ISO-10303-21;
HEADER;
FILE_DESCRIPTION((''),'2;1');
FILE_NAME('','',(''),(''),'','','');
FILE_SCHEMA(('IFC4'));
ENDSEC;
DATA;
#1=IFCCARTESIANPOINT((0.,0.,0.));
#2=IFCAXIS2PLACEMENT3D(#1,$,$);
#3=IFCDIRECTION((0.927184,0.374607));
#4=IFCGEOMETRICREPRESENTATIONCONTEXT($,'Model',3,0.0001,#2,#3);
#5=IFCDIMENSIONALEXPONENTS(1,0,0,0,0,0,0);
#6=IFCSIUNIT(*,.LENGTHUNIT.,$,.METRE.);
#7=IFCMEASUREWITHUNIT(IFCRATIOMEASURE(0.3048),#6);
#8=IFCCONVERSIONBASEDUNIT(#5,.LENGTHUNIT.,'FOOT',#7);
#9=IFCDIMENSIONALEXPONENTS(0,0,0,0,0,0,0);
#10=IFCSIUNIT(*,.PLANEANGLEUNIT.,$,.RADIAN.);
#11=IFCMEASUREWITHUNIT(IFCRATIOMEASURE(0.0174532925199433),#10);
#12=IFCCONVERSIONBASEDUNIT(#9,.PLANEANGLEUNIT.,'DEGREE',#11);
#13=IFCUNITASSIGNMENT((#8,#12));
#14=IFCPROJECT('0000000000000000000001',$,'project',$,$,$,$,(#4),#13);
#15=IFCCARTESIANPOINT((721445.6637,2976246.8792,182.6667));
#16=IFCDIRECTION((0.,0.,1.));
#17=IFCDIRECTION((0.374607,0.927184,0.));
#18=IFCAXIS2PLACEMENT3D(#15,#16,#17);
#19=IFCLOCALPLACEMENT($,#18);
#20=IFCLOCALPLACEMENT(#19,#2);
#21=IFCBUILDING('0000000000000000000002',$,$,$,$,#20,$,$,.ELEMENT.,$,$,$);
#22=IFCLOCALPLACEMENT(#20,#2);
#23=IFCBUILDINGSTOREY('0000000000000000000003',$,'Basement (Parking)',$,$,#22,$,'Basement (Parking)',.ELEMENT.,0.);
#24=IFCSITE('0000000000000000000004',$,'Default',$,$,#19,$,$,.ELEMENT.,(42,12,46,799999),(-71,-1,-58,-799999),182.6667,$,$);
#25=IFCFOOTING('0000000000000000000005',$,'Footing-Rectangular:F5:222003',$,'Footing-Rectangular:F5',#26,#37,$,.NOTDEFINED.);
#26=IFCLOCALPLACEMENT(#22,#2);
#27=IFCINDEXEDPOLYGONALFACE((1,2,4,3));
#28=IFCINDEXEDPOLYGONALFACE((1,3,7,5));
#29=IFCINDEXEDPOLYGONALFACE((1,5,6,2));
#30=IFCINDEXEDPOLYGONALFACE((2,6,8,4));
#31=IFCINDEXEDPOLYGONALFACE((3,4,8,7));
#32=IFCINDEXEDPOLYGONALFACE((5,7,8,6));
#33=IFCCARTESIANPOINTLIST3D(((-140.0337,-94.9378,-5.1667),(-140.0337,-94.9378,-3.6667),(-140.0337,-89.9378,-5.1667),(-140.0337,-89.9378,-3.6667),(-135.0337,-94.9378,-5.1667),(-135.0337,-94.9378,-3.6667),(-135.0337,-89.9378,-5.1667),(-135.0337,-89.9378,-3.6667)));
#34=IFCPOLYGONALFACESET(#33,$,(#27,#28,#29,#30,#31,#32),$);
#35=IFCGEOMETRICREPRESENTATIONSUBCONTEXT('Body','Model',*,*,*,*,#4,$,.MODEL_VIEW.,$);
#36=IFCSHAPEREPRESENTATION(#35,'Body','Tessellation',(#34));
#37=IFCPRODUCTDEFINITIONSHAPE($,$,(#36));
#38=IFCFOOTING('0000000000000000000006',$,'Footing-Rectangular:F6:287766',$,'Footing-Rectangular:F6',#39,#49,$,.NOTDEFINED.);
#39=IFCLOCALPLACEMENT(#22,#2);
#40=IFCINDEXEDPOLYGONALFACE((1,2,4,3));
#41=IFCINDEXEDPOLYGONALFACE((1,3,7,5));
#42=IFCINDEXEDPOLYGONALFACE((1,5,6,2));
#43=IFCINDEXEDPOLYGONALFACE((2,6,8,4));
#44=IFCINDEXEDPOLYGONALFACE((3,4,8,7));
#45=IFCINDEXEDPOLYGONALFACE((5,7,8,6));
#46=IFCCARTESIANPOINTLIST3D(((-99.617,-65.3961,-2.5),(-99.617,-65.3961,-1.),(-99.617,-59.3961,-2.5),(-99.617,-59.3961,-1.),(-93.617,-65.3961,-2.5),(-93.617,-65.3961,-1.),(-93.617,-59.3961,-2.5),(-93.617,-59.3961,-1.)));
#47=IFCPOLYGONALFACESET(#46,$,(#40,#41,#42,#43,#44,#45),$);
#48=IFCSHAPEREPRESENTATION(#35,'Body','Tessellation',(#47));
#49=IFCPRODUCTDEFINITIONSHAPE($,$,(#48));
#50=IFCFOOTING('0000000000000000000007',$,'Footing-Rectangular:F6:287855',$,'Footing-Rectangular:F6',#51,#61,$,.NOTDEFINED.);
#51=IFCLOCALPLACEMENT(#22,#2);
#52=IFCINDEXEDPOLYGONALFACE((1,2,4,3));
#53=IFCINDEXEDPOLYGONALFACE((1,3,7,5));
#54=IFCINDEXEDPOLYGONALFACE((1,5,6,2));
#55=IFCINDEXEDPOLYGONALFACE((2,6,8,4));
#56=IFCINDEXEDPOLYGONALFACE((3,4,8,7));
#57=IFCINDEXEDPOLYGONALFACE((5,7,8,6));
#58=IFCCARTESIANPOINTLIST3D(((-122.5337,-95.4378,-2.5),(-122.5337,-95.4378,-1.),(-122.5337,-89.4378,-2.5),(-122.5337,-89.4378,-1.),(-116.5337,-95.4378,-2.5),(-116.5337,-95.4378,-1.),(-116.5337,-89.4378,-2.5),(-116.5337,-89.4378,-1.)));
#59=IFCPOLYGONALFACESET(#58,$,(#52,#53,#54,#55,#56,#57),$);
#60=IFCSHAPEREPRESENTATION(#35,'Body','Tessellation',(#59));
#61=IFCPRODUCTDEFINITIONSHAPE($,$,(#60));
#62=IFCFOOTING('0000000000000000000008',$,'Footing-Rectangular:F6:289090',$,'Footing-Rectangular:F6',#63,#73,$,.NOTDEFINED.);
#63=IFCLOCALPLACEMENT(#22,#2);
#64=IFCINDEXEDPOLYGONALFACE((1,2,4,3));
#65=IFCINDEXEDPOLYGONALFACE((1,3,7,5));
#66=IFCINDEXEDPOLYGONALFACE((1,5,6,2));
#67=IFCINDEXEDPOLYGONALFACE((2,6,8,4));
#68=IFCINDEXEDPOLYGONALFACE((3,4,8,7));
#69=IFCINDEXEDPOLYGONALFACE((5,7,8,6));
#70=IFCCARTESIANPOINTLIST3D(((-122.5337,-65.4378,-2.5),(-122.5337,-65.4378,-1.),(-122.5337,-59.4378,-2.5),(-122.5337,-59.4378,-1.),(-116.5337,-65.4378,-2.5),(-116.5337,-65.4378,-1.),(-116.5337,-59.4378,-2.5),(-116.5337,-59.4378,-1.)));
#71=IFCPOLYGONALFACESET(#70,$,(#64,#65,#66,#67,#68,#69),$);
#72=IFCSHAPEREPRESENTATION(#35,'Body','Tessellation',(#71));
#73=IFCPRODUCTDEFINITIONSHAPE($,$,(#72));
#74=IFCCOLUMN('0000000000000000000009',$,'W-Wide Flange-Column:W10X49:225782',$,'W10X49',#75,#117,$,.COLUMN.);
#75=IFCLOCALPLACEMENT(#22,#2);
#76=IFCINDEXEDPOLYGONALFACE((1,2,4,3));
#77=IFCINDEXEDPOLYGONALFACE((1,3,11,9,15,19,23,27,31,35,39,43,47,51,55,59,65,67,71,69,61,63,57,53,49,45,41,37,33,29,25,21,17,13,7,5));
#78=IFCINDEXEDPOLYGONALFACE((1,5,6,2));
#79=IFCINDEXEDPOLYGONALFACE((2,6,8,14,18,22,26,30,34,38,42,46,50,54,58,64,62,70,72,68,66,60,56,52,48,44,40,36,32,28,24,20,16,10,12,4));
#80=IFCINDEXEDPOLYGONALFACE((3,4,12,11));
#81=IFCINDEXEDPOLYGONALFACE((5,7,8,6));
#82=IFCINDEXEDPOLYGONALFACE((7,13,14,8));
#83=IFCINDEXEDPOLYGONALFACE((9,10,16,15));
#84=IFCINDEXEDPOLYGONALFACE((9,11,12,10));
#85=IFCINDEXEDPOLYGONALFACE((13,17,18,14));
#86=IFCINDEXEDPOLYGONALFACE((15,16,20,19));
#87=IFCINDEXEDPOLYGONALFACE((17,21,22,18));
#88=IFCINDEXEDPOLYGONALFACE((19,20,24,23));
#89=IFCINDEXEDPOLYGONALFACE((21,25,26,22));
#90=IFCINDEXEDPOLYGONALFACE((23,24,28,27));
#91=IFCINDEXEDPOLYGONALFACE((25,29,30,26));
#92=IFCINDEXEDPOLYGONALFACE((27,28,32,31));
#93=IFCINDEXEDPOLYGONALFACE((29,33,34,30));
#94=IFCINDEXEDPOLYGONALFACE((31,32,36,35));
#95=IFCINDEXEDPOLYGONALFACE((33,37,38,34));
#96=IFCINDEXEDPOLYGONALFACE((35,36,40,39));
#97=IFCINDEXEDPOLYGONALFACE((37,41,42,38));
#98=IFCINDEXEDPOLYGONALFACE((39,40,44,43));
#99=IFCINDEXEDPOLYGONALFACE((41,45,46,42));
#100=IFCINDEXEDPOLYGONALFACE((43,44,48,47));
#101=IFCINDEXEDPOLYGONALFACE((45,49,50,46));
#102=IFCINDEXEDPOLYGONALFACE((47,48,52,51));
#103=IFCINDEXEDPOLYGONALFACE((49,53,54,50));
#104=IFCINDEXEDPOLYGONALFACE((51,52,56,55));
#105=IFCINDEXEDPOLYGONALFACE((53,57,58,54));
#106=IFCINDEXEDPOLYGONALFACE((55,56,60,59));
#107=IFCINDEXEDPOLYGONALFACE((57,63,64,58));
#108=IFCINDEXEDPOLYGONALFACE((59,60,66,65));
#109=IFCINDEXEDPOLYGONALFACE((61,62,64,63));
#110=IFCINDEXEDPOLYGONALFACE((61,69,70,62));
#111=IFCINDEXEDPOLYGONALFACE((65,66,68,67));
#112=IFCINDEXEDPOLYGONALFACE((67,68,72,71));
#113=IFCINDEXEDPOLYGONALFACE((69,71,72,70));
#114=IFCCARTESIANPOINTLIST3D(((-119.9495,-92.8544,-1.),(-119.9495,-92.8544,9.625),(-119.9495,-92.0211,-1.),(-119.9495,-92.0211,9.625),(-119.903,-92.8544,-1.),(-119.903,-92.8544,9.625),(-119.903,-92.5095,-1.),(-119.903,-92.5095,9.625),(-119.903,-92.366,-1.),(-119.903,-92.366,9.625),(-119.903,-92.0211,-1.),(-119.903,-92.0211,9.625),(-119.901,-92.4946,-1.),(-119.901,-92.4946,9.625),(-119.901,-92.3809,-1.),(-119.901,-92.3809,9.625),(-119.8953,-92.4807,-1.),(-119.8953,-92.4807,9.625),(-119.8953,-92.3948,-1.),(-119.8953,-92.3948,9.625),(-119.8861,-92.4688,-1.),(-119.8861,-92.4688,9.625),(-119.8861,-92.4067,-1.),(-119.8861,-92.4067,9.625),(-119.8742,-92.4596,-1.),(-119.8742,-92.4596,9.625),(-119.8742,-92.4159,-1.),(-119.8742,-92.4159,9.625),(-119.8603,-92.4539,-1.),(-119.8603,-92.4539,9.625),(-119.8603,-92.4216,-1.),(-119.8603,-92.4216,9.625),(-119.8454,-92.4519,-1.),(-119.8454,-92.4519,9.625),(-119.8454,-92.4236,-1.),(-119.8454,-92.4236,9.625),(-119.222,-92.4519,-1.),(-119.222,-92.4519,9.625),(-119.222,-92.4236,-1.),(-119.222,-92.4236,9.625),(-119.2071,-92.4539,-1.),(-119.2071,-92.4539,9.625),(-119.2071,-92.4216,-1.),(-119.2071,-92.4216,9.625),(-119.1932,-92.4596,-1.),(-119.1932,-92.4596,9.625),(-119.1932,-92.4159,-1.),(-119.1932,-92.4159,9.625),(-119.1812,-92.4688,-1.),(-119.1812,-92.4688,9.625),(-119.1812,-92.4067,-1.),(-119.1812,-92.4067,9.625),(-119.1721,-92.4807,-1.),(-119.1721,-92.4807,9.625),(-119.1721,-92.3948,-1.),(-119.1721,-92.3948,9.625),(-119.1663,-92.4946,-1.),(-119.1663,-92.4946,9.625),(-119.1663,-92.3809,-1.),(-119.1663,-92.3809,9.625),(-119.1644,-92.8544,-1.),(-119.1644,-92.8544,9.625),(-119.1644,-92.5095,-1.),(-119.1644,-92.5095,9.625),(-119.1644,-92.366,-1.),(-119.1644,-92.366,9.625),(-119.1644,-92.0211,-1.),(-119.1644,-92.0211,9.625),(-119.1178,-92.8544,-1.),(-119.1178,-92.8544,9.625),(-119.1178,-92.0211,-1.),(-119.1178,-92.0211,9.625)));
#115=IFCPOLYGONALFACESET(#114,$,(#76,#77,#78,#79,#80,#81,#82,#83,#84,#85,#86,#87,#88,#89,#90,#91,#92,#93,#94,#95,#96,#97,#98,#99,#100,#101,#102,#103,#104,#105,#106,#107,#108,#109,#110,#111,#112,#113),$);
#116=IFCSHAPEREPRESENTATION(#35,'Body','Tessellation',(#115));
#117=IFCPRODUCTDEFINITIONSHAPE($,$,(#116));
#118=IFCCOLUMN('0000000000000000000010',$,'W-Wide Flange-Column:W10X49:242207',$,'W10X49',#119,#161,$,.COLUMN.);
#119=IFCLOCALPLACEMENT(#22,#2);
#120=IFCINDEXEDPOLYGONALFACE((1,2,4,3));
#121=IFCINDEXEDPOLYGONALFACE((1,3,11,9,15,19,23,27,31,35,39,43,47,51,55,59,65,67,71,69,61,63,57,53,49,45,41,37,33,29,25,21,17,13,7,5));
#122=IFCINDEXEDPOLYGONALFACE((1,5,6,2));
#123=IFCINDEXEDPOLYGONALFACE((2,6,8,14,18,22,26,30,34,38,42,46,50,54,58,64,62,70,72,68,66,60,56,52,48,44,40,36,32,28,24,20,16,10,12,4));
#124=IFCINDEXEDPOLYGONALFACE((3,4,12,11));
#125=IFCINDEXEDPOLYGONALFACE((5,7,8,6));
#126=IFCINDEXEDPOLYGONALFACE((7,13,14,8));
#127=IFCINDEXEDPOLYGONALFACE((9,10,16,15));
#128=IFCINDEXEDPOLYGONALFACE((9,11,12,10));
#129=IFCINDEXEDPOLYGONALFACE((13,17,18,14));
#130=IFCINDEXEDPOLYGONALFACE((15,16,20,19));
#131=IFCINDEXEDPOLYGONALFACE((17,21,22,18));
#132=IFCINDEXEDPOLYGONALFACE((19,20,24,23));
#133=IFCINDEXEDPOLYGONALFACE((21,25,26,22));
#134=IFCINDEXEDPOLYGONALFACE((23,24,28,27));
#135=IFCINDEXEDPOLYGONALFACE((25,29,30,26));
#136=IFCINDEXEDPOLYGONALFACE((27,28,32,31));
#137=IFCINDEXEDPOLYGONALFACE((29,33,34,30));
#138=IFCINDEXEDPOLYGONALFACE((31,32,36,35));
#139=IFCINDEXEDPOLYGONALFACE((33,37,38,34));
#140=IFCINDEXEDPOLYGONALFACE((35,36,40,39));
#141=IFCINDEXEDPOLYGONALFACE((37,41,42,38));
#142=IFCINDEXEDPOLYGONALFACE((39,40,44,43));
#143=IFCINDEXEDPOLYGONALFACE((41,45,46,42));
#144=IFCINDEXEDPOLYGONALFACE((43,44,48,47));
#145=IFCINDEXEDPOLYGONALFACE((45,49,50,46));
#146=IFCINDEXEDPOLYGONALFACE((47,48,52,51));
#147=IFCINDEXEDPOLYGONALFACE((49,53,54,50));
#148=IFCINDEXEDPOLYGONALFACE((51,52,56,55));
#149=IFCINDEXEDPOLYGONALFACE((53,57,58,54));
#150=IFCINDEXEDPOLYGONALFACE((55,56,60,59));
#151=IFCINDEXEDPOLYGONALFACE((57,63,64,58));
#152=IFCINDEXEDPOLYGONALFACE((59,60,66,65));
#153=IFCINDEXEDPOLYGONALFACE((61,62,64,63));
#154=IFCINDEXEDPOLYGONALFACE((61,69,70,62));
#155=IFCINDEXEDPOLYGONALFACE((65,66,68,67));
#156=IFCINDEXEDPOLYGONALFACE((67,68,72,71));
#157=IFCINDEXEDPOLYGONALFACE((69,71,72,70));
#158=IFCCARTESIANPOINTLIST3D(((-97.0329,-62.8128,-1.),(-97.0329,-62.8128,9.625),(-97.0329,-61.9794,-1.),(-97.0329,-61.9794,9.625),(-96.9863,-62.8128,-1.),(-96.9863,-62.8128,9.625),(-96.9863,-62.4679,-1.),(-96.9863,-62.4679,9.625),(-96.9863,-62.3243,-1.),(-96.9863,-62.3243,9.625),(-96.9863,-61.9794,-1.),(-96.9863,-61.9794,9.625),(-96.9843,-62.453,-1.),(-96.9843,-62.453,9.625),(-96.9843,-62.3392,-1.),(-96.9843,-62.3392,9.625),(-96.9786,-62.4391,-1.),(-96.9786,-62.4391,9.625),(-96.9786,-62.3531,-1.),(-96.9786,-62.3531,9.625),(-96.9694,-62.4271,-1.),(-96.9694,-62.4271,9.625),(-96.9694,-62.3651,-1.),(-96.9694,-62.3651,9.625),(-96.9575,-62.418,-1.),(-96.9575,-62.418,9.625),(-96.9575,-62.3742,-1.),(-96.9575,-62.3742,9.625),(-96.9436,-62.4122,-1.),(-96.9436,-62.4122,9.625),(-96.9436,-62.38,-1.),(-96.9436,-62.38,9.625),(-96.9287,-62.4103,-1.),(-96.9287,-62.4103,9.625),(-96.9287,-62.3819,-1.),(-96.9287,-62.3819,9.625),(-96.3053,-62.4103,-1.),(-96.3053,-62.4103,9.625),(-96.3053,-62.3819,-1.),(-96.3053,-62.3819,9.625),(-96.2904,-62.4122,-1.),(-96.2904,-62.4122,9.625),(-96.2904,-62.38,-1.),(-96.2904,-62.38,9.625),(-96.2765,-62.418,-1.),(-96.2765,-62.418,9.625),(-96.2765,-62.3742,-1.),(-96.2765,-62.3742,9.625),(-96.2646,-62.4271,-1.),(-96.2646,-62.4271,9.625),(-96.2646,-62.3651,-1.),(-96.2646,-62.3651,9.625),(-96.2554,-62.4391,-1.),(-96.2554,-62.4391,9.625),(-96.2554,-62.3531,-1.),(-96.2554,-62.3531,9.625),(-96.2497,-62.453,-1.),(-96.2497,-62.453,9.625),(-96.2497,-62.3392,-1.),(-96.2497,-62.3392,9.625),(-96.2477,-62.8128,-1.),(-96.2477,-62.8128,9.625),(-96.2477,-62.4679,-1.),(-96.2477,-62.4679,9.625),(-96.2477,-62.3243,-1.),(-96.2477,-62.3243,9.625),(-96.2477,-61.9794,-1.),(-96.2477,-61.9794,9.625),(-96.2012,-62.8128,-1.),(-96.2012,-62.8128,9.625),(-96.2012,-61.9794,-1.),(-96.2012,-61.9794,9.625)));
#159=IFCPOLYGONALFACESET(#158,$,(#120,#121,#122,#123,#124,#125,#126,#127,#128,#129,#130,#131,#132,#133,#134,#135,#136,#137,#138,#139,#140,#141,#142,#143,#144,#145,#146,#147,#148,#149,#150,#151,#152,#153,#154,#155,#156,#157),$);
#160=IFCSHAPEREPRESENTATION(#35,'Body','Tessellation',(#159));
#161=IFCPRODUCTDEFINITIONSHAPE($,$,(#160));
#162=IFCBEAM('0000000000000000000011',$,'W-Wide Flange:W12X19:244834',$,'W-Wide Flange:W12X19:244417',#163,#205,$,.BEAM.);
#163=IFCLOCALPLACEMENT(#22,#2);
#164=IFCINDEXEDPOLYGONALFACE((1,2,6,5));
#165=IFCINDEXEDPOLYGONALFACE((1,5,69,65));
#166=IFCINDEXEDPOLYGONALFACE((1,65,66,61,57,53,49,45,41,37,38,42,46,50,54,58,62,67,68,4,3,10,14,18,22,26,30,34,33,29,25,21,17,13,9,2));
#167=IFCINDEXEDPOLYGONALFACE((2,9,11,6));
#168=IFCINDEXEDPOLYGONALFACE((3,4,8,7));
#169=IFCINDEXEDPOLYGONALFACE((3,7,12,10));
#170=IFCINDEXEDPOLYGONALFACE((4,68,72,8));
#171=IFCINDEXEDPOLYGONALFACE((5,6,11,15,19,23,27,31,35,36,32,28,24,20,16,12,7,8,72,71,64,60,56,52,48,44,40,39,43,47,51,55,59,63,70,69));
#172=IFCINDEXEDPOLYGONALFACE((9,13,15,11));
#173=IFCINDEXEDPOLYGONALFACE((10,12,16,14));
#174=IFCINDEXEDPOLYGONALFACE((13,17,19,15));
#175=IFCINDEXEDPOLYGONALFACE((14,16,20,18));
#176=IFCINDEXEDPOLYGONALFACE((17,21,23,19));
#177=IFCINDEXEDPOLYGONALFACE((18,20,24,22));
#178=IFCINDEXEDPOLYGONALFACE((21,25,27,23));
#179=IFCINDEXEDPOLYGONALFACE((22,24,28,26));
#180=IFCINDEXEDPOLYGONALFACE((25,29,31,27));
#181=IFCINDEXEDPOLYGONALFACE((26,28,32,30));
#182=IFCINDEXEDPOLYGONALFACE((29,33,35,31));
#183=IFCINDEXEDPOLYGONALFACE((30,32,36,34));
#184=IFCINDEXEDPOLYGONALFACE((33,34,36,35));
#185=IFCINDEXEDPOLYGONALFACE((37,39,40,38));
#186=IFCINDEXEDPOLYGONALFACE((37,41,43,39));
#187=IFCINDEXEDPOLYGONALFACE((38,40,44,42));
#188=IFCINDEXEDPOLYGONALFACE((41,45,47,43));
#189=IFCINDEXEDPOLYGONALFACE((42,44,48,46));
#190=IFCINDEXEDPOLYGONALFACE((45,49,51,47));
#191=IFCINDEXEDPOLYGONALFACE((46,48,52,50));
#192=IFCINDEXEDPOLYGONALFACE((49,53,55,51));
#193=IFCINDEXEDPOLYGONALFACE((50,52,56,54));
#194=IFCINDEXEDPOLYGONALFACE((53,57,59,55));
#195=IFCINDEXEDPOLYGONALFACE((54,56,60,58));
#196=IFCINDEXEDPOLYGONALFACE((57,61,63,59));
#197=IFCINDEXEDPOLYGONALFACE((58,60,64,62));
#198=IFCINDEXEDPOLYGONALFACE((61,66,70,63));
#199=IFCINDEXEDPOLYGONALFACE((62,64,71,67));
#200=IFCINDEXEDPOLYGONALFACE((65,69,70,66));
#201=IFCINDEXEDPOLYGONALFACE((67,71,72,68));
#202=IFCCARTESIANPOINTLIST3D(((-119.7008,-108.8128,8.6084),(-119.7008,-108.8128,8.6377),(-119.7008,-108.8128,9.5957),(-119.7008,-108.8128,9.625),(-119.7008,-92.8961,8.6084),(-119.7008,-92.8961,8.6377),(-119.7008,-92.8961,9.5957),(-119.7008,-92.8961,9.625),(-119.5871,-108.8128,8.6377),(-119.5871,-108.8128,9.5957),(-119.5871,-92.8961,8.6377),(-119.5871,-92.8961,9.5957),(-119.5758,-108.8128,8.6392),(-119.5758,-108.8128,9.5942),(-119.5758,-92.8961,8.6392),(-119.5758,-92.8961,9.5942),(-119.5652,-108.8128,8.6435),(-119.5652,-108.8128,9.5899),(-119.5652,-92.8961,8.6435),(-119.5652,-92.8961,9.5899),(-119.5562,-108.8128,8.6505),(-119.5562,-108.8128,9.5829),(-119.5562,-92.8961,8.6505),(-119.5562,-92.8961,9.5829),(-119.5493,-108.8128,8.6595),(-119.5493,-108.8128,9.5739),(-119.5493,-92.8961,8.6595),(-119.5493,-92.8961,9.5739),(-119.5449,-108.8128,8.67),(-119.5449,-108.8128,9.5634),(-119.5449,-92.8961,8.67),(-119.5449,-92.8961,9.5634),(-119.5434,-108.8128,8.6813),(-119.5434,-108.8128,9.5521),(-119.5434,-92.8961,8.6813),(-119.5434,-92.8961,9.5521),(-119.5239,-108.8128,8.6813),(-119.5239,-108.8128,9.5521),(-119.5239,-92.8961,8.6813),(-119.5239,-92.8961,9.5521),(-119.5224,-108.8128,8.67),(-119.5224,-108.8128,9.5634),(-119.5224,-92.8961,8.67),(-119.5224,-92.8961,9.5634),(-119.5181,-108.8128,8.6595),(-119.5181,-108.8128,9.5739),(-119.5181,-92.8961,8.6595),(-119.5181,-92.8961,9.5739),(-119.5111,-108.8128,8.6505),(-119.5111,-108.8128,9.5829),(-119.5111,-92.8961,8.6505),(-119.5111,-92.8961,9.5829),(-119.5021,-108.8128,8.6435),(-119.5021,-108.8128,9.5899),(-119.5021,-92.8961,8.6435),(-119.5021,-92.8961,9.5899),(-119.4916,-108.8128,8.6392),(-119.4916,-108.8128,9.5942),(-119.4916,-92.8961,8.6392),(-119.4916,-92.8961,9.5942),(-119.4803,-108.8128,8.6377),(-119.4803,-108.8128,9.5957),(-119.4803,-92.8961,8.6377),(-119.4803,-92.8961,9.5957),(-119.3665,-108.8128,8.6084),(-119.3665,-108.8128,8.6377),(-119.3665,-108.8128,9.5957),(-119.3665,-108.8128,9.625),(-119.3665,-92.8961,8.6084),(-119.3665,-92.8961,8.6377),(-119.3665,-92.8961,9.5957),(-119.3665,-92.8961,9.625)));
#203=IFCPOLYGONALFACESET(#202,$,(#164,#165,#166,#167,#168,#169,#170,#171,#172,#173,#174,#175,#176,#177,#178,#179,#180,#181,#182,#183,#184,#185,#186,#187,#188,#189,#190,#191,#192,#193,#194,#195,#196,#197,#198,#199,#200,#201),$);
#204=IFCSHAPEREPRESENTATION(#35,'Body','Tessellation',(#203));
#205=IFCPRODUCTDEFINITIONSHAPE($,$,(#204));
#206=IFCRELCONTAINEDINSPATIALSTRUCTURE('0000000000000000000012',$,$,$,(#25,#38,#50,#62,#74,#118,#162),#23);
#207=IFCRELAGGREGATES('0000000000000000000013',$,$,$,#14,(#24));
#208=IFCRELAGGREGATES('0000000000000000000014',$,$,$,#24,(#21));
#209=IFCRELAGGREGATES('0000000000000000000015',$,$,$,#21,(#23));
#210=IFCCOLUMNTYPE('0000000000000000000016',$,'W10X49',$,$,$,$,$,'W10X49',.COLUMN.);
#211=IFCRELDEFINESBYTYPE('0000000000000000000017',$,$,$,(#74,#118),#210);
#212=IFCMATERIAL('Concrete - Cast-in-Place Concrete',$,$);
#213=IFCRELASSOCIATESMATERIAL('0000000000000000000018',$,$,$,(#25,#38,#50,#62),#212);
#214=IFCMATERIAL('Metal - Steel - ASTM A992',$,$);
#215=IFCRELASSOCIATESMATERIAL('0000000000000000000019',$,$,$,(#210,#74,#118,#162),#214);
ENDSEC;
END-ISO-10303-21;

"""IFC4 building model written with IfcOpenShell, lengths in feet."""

from ifc_helpers import new_model, entity, si_unit, converted_unit, direction, frame, frame_2d, origin, origin_2d_with_axis, place, context, subcontext, project, spatial, rectangle, i_section, extrude, source, transform, mapped, material, type_object, type_shapes, element, save


model = new_model("IFC4")

# Units and contexts
model_context = context("Model", 3, precision=0.0001, world=origin(), true_north=direction((0.927184, 0.374607)))
body_context = subcontext(model_context, "Body", "Model", "MODEL_VIEW")
ifc_project = project(units=[converted_unit("LENGTHUNIT", "FOOT", entity("IfcRatioMeasure", 0.3048), si_unit("LENGTHUNIT", "METRE"), dimensions=[1, 0, 0, 0, 0, 0, 0]), converted_unit("PLANEANGLEUNIT", "DEGREE", entity("IfcRatioMeasure", 0.0174532925199433), si_unit("PLANEANGLEUNIT", "RADIAN"), dimensions=[0, 0, 0, 0, 0, 0, 0])], contexts=[model_context])

# Site, building, storey
site_placement = place(None, frame((721445.6637, 2976246.8792, 182.6667), z_axis=(0.0, 0.0, 1.0), x_axis=(0.374607, 0.927184, 0.0)))
site = spatial("IfcSite", under=ifc_project, at=site_placement, Name="Default", CompositionType="ELEMENT", RefLatitude=(42, 12, 46, 799999), RefLongitude=(-71, -1, -58, -799999), RefElevation=182.6667)
building_placement = place(site_placement, origin())
building = spatial("IfcBuilding", under=site, at=building_placement, CompositionType="ELEMENT")
storey_placement = place(building_placement, origin())
storey = spatial("IfcBuildingStorey", under=building, at=storey_placement, Name="Basement (Parking)", LongName="Basement (Parking)", CompositionType="ELEMENT", Elevation=0.0)

# Footings
ifc_material_1 = material(Name="Concrete - Cast-in-Place Concrete")
footing_placement = place(storey_placement, frame((-140.0337, -94.9378, -5.1667)))
element("IfcFooting", 1, at=footing_placement, inside=storey, material=ifc_material_1, Name="Footing-Rectangular:F5:222003", ObjectType="Footing-Rectangular:F5", PredefinedType="NOTDEFINED", context=body_context, shape_type="SweptSolid", body=[
    extrude(rectangle(XDim=5.0, YDim=5.0, at=frame_2d((0.5, 0.0), x_axis=(1.0, 0.0))), frame((3.0, 2.5, 0.0), z_axis=(0.0, 0.0, 1.0), x_axis=(-1.0, 0.0, 0.0)), (0.0, 0.0, 1.0), 1.5),
])
for number, where, name in (
    (2, (-99.617, -65.3961, -2.5), "Footing-Rectangular:F6:287766"),
    (3, (-122.5337, -95.4378, -2.5), "Footing-Rectangular:F6:287855"),
    (4, (-122.5337, -65.4378, -2.5), "Footing-Rectangular:F6:289090"),
):
    element("IfcFooting", number, at=place(storey_placement, frame(where)), inside=storey, material=ifc_material_1, Name=name, ObjectType="Footing-Rectangular:F6", PredefinedType="NOTDEFINED", context=body_context, shape_type="SweptSolid", body=[
        extrude(rectangle(XDim=6.0, YDim=6.0, at=origin_2d_with_axis()), frame((3.0, 3.0, 0.0), z_axis=(0.0, 0.0, 1.0), x_axis=(-1.0, 0.0, 0.0)), (0.0, 0.0, 1.0), 1.5),
    ])

# Columns
ifc_material_2 = material(Name="Metal - Steel - ASTM A992")
column_type = type_object("IfcColumnType", Name="W10X49", ElementType="W10X49", PredefinedType="COLUMN", material=ifc_material_2)
shared_shape = source(origin(), body_context, "Body", "SweptSolid", [
    extrude(i_section(OverallWidth=0.8333, OverallDepth=0.8317, WebThickness=0.0283, FlangeThickness=0.0465, FilletRadius=0.0576, at=frame_2d((0.0, 0.0), x_axis=(0.0, 1.0))), frame((0.0, 0.0, -1.0), z_axis=(0.0, 0.0, 1.0), x_axis=(0.0, -1.0, 0.0)), (0.0, 0.0, 1.0), 10.625),
])
type_shapes(column_type, [shared_shape])
for number, where, z_axis, x_axis, name in (
    (5, (-119.5337, -92.4378, 0.0), (0.0, 0.0, 1.0), (0.0, 1.0, 0.0), "W-Wide Flange-Column:W10X49:225782"),
    (6, (-96.617, -62.3961, 0.0), (0.0, 0.0, 1.0), (0.0, 1.0, 0.0), "W-Wide Flange-Column:W10X49:242207"),
):
    element("IfcColumn", number, at=place(storey_placement, frame(where, z_axis=z_axis, x_axis=x_axis)), inside=storey, type_object=column_type, material=ifc_material_2, Name=name, ObjectType="W10X49", PredefinedType="COLUMN", context=body_context, shape_type="MappedRepresentation", body=[
        mapped(shared_shape, transform((0.0, 0.0, 0.0), scale=1.0)),
    ])

# Beam
beam_1_placement = place(storey_placement, frame((-119.5337, -92.4378, 9.625), z_axis=(0.0, 0.0, 1.0), x_axis=(0.0, -1.0, 0.0)))
element("IfcBeam", 7, at=beam_1_placement, inside=storey, material=ifc_material_2, Name="W-Wide Flange:W12X19:244834", ObjectType="W-Wide Flange:W12X19:244417", PredefinedType="BEAM", context=body_context, shape_type="SweptSolid", body=[
    extrude(i_section(OverallWidth=0.3343, OverallDepth=1.0166, WebThickness=0.0195, FlangeThickness=0.0293, FilletRadius=0.0436, at=frame_2d((0.0, 0.0), x_axis=(0.0, 1.0))), frame((0.4583, 0.0, -0.5083), z_axis=(1.0, 0.0, 0.0), x_axis=(0.0, 0.0, -1.0)), (0.0, 0.0, 1.0), 15.9167),
])

save(model, "model.ifc")
